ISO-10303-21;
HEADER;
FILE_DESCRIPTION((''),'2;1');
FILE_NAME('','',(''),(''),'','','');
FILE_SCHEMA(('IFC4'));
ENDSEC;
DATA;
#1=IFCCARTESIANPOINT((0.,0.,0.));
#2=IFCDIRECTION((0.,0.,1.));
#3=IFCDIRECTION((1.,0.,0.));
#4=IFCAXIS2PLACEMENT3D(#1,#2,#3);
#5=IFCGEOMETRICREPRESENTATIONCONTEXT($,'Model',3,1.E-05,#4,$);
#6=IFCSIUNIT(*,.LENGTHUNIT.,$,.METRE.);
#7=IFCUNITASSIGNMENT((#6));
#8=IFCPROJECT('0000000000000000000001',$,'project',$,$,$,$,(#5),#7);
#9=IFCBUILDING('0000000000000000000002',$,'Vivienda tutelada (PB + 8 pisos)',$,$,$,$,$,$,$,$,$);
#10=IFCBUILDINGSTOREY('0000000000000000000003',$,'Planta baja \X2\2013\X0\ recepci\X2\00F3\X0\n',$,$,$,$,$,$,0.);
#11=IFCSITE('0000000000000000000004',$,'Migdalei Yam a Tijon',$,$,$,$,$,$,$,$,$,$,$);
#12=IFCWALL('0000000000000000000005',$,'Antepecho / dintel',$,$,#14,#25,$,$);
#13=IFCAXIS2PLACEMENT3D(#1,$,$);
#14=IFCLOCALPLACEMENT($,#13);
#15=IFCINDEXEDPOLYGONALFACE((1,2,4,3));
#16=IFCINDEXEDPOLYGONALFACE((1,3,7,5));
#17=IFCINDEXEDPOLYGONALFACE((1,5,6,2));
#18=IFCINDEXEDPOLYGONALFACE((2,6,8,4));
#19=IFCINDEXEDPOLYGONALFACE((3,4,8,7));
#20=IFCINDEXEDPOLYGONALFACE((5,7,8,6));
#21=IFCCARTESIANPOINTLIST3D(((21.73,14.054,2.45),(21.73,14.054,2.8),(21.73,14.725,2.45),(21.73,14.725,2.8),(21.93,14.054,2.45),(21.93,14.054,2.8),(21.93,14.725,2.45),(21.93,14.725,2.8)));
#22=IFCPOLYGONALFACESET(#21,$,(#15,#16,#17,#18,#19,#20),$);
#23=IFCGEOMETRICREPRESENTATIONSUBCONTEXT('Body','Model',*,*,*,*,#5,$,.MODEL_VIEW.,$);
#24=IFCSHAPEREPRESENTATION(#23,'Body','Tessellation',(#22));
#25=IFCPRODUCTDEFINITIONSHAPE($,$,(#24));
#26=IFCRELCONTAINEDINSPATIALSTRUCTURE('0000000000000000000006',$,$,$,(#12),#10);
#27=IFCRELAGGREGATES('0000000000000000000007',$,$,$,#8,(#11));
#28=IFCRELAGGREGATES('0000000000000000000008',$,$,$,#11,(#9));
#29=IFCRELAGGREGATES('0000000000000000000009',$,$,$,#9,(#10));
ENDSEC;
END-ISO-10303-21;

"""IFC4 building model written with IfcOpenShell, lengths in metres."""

from ifc_helpers import new_model, si_unit, frame, origin_with_axes, context, subcontext, project, spatial, line, indexed_curve, outline, extrude, element, save


model = new_model("IFC4")

# Units and contexts
model_context = context("Model", 3, precision=1e-05, world=origin_with_axes())
body_context = subcontext(model_context, "Body", "Model", "MODEL_VIEW")
ifc_project = project(units=[si_unit("LENGTHUNIT", "METRE")], contexts=[model_context])

# Site, building, storey
site = spatial("IfcSite", under=ifc_project, Name="Migdalei Yam a Tijon")
building = spatial("IfcBuilding", under=site, Name="Vivienda tutelada (PB + 8 pisos)")
storey = spatial("IfcBuildingStorey", under=building, Name="Planta baja – recepción", Elevation=0.0)

# Wall
element("IfcWall", 1, inside=storey, Name="Antepecho / dintel", context=body_context, shape_type="SweptSolid", body=[
    extrude(outline(indexed_curve([(0.0, 0.0), (0.2, 0.0), (0.2, 0.671), (0.0, 0.671)], segments=[line(1, 2, 3, 4, 1)])), frame((21.73, 14.054, 2.45), z_axis=(0.0, 0.0, 1.0), x_axis=(1.0, 0.0, 0.0)), (0.0, 0.0, 1.0), 0.35),
])

save(model, "model.ifc")
